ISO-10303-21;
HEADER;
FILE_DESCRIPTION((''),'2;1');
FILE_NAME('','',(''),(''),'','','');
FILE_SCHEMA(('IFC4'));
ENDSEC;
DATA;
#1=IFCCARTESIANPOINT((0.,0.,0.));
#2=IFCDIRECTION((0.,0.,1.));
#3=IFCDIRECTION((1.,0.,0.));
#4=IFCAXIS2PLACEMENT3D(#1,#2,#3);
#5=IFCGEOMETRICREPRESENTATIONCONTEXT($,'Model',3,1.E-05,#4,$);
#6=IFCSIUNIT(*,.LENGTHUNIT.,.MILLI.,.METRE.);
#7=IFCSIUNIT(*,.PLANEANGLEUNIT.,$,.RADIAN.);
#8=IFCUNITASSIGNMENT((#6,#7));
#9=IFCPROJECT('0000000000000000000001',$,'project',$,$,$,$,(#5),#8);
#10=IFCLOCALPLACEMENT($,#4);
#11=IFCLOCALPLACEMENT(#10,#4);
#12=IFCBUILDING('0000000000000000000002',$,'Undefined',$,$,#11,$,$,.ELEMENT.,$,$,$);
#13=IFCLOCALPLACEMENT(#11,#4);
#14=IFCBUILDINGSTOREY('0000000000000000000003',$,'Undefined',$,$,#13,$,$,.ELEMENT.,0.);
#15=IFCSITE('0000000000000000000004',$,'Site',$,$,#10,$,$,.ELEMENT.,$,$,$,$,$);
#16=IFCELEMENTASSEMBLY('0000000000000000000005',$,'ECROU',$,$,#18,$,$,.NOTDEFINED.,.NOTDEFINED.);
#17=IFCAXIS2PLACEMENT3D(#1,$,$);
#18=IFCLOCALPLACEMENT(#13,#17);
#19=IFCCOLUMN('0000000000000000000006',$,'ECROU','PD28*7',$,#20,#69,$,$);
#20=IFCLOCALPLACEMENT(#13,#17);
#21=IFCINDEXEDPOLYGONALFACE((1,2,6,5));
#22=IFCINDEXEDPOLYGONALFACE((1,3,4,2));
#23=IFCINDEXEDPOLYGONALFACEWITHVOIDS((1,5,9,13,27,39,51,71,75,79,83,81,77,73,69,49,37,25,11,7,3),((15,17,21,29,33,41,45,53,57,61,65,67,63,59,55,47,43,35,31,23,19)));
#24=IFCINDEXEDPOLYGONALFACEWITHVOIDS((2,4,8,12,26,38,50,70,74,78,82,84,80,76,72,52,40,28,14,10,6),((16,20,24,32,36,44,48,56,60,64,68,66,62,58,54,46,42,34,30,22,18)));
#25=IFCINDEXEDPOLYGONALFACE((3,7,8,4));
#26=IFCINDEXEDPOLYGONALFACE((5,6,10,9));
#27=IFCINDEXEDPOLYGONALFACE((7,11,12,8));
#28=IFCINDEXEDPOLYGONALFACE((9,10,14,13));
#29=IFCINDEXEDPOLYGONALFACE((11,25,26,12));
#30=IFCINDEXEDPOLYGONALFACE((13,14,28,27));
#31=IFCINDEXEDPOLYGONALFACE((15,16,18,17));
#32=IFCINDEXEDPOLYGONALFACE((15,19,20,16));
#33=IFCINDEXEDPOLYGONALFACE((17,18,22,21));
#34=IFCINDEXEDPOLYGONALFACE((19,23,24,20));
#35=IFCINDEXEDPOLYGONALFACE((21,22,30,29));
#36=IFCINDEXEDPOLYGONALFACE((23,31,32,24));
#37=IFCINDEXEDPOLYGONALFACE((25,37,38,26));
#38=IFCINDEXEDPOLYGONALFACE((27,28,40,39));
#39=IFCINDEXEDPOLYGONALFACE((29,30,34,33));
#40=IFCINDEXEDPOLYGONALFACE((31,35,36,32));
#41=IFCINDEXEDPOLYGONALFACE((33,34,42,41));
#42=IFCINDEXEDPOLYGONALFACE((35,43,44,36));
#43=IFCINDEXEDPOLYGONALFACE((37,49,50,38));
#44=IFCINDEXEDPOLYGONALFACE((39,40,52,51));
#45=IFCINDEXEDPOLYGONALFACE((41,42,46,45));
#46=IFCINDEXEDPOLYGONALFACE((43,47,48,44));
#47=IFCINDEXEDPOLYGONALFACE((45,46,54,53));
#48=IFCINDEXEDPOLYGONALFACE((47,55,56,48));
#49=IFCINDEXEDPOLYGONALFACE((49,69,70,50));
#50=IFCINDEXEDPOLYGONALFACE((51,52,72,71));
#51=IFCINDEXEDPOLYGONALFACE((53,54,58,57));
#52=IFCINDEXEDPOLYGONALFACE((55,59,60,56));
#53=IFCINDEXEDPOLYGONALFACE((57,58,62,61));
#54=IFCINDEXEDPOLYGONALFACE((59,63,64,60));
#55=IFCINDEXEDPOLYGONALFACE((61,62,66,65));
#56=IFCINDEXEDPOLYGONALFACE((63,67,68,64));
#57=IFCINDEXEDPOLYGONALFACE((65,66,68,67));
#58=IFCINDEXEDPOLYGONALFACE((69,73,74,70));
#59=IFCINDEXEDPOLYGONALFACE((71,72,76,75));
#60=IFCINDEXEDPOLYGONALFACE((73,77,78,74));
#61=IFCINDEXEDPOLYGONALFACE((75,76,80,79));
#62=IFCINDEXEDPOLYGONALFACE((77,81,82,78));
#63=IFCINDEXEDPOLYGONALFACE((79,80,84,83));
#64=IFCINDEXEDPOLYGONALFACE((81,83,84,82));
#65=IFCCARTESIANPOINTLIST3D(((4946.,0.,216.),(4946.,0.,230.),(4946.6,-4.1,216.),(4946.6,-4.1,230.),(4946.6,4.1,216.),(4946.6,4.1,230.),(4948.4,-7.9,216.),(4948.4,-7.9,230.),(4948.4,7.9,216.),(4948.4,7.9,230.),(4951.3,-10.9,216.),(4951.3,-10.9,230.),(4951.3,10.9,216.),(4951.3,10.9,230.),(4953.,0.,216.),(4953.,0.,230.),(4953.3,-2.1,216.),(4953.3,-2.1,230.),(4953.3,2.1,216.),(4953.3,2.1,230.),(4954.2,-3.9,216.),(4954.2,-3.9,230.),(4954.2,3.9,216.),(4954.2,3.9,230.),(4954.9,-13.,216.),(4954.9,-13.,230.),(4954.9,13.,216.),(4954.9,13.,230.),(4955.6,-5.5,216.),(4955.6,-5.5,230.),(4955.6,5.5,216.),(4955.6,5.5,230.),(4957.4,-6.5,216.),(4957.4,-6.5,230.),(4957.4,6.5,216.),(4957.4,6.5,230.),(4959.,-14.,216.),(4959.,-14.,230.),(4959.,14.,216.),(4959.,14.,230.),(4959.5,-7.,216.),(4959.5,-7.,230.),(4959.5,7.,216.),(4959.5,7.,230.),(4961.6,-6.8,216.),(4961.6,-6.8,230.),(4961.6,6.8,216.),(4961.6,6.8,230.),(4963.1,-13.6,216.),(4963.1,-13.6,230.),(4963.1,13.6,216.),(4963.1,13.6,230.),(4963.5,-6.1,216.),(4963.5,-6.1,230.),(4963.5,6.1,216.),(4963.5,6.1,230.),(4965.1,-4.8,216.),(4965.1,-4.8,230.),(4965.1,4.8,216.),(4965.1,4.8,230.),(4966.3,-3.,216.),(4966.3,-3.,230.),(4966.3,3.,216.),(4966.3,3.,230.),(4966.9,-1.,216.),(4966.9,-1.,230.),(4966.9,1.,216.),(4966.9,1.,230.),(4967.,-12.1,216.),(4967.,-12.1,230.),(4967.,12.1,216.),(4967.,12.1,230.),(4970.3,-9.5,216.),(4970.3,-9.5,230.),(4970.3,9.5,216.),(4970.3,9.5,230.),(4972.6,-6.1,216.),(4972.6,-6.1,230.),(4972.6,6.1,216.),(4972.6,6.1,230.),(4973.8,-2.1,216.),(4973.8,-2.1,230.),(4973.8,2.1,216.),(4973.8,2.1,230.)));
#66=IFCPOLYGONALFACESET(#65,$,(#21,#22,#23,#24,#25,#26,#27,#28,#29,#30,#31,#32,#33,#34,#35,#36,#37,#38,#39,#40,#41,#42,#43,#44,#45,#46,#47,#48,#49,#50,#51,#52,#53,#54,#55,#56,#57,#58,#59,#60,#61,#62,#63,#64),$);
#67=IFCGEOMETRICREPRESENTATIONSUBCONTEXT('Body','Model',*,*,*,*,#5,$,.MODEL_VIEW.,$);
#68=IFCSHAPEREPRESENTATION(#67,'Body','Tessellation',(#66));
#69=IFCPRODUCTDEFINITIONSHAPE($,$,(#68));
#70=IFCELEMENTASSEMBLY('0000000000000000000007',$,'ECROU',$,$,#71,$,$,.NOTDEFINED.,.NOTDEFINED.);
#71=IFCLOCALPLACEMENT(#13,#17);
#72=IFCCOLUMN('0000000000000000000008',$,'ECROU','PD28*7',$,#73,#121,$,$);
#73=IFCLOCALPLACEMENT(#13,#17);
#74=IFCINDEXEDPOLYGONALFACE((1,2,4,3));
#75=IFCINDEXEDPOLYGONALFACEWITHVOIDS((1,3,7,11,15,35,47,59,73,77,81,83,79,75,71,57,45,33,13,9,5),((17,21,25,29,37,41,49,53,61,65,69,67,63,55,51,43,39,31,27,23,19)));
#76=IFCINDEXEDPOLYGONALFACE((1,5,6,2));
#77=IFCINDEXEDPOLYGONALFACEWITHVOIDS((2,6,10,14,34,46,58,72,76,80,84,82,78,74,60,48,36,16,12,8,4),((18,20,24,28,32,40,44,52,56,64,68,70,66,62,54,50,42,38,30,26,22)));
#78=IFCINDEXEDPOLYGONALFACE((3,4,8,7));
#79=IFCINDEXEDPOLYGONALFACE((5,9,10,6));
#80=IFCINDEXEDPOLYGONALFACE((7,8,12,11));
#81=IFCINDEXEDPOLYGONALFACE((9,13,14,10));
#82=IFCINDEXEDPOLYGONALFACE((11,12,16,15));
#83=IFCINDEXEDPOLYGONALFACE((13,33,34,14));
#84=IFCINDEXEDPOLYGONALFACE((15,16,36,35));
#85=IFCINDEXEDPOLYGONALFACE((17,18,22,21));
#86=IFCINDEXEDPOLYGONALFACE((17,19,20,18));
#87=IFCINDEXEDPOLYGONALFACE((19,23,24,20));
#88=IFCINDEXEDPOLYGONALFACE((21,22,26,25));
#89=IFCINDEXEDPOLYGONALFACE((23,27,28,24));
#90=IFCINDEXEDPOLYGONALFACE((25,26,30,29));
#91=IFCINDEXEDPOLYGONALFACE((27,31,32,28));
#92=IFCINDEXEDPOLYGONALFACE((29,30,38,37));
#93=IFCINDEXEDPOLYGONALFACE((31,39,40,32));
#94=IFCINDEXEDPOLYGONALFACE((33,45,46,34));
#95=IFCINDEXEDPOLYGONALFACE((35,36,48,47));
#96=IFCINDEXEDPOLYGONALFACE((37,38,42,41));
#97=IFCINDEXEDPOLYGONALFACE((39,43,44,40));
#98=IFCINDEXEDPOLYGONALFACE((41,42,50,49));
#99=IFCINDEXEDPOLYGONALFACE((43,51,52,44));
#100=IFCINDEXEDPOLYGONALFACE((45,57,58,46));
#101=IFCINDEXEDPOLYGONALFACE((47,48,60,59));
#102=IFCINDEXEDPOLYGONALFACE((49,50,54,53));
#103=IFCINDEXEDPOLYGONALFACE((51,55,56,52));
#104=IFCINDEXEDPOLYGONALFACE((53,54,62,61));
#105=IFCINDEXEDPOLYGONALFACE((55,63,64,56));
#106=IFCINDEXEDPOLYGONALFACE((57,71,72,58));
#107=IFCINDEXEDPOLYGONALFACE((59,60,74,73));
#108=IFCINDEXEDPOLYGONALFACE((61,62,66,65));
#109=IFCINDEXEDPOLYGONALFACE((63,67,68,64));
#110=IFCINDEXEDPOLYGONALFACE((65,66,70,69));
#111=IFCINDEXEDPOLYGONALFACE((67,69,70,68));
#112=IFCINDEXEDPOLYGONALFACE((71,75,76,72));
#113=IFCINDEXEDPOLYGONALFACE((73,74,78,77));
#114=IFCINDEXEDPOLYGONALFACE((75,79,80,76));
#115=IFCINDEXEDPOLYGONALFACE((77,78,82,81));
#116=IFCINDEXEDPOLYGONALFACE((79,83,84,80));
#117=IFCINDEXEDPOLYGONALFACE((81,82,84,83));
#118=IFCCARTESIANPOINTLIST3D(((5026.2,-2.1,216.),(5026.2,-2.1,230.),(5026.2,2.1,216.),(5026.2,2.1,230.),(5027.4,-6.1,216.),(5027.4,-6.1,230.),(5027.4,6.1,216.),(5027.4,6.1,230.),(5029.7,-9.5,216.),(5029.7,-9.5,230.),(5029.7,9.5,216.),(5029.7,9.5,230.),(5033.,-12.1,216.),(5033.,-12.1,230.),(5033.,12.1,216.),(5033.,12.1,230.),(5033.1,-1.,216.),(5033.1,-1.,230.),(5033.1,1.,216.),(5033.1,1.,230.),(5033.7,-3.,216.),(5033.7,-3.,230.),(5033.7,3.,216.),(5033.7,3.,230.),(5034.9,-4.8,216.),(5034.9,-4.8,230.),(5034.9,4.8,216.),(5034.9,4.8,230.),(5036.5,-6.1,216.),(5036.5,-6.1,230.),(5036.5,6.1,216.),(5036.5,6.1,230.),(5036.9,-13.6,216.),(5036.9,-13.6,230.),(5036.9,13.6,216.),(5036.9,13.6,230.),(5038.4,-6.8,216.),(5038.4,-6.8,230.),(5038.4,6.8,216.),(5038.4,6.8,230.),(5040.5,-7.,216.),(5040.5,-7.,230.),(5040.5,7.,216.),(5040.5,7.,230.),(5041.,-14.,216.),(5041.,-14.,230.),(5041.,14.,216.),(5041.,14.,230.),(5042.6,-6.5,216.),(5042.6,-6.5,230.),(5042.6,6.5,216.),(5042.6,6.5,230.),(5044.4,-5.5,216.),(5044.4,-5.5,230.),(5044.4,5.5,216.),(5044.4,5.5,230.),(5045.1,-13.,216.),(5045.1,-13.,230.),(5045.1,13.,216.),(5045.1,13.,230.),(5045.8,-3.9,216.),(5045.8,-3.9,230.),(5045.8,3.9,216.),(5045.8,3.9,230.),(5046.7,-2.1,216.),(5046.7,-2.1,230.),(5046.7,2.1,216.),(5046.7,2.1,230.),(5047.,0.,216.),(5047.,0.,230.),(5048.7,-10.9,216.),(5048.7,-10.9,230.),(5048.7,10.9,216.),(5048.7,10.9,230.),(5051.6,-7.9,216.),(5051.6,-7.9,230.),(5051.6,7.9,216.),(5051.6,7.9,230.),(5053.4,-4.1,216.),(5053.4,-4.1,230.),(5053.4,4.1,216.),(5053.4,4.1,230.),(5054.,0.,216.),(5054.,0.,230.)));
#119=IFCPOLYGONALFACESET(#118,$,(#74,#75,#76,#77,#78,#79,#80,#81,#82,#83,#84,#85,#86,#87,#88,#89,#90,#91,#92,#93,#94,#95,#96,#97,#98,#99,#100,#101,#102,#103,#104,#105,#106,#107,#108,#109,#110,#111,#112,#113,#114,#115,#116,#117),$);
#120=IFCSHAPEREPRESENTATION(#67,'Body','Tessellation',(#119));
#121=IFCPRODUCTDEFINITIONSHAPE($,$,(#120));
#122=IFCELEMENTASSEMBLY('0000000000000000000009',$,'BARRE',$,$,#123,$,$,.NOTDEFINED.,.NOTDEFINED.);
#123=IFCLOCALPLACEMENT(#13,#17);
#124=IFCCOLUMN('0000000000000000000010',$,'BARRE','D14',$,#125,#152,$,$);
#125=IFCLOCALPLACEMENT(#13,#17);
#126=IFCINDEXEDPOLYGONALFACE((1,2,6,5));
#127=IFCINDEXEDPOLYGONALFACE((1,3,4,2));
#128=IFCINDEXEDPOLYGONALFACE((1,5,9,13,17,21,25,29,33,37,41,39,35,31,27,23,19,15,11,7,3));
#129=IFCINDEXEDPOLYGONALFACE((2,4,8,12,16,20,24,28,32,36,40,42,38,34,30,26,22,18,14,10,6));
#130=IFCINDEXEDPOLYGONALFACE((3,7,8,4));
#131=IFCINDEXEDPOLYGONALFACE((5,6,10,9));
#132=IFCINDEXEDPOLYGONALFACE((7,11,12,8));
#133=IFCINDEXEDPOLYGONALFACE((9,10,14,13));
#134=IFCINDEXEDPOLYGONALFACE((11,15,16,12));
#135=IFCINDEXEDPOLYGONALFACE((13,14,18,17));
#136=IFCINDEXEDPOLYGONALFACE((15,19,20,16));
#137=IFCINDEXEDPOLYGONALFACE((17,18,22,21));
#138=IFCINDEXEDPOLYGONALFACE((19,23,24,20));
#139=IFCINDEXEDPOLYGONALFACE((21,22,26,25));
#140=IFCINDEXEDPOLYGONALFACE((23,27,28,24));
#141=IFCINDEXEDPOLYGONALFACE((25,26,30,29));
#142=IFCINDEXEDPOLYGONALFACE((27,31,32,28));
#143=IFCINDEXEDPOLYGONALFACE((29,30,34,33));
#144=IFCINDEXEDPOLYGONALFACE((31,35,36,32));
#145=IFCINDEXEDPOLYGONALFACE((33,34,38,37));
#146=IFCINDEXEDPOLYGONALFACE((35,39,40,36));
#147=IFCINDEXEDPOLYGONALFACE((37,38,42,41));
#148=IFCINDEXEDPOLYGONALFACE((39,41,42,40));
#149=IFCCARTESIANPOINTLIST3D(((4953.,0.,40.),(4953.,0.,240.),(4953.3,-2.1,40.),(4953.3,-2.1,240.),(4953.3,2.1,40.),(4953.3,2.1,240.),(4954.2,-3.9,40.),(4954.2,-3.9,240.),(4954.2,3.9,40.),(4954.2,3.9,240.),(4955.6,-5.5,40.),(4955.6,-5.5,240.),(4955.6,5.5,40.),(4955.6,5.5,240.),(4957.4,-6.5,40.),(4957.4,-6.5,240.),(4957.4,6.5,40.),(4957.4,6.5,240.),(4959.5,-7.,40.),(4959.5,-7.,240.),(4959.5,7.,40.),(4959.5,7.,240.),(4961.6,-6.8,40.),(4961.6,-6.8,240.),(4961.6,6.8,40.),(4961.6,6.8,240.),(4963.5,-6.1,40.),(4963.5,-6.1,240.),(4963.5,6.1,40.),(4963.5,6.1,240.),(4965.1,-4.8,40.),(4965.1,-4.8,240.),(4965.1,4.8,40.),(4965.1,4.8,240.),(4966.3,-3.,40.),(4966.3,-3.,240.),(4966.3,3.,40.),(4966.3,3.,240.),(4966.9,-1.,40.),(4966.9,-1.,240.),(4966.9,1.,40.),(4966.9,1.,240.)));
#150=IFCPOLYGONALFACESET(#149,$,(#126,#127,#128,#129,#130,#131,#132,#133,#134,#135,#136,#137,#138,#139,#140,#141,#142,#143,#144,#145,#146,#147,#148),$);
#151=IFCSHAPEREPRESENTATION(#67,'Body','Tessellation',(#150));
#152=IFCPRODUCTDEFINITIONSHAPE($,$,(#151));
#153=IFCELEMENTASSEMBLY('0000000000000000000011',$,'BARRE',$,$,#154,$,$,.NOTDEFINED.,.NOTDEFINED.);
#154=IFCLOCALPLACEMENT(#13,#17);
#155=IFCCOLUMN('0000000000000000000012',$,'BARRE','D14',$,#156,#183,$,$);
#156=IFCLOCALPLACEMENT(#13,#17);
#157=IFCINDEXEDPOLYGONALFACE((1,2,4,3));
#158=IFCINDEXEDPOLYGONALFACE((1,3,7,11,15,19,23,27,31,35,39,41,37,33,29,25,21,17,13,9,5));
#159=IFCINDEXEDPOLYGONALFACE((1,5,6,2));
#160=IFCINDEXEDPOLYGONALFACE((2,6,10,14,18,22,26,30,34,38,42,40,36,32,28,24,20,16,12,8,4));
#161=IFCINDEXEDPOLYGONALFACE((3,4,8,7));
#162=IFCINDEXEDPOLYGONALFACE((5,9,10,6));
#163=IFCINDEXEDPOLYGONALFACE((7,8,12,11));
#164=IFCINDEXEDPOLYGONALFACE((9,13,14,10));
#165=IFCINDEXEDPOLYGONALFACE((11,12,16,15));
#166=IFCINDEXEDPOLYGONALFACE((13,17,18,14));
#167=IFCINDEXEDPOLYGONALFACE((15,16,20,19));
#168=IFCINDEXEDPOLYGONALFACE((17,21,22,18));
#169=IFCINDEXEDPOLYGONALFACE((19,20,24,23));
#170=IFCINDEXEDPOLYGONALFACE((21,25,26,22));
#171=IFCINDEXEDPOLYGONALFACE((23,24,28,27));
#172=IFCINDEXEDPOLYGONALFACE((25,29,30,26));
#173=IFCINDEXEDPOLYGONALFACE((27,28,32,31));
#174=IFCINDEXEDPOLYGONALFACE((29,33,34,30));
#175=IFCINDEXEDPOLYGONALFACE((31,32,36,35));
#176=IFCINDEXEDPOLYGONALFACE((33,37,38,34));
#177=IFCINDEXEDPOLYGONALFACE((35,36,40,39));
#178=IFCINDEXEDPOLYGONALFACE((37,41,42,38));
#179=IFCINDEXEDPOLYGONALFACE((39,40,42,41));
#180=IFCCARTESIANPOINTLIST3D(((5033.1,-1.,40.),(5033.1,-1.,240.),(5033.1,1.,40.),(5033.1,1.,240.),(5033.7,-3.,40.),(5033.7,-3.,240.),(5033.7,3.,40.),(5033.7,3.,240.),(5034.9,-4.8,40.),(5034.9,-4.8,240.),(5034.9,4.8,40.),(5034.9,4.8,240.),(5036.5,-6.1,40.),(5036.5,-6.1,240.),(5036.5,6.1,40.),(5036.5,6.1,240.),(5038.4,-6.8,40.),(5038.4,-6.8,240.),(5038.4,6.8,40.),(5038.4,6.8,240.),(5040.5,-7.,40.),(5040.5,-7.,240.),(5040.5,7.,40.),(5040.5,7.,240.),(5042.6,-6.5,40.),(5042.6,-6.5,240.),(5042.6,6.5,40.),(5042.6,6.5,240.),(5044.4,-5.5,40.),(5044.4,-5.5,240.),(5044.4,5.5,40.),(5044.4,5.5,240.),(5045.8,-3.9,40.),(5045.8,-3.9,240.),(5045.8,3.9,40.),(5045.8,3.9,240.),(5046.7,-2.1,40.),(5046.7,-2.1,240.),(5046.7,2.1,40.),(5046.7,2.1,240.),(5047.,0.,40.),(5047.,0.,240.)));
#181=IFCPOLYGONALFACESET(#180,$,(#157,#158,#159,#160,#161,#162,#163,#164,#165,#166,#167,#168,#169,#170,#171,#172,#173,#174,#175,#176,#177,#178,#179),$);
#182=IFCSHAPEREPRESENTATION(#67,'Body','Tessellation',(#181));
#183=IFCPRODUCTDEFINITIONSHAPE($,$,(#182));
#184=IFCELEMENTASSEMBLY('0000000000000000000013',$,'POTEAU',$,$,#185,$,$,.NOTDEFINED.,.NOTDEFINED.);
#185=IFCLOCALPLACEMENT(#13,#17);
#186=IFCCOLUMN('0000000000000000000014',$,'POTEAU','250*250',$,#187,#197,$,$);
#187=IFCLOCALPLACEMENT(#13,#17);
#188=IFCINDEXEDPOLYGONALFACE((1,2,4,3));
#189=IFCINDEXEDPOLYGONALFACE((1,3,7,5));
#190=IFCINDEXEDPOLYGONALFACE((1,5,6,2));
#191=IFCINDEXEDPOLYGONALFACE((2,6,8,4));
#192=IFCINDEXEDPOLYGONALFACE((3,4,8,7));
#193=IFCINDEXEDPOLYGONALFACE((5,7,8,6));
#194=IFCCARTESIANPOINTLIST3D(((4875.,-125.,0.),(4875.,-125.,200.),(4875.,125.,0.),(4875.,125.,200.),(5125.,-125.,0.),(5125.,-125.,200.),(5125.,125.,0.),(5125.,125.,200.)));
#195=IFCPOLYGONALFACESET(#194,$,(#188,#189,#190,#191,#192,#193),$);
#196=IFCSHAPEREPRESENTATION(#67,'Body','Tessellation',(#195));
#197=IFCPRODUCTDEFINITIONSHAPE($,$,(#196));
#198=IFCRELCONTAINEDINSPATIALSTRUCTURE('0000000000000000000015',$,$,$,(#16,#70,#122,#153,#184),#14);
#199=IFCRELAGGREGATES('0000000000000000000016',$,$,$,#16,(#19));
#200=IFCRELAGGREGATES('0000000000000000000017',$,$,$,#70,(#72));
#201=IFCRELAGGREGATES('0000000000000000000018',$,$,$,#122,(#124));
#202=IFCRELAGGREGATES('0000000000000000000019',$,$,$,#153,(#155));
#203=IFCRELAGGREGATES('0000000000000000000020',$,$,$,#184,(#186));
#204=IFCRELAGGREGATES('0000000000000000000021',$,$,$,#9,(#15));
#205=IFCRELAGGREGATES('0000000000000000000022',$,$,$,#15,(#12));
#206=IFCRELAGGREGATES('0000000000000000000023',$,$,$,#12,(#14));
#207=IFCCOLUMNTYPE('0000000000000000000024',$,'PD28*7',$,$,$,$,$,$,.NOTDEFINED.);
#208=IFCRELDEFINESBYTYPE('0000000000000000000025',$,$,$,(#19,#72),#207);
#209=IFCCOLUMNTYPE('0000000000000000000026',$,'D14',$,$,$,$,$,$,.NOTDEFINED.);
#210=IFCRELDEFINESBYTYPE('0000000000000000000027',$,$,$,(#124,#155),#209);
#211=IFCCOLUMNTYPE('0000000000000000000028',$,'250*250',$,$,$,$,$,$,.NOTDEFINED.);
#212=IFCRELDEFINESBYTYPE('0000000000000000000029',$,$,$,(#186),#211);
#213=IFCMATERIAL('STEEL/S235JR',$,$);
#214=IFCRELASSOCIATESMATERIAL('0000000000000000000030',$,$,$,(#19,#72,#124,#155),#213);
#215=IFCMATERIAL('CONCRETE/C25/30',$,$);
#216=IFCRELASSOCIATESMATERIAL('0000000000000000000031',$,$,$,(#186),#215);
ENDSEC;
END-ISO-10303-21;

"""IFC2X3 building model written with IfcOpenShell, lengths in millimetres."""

from ifc_helpers import new_model, si_unit, frame, origin_with_axes, origin_2d_with_axis, place, context, subcontext, project, spatial, rectangle, circle, hollow_circle, extrude, material, type_object, element, aggregate, save


model = new_model("IFC2X3")

# Units and contexts
model_context = context("Model", 3, precision=1e-05, world=origin_with_axes())
body_context = subcontext(model_context, "Body", "Model", "MODEL_VIEW")
ifc_project = project(units=[si_unit("LENGTHUNIT", "METRE", prefix="MILLI"), si_unit("PLANEANGLEUNIT", "RADIAN")], contexts=[model_context])

# Site, building, storey
site_placement = place(None, origin_with_axes())
site = spatial("IfcSite", under=ifc_project, at=site_placement, Name="Site", CompositionType="ELEMENT")
building_placement = place(site_placement, origin_with_axes())
building = spatial("IfcBuilding", under=site, at=building_placement, Name="Undefined", CompositionType="ELEMENT")
storey_placement = place(building_placement, origin_with_axes())
storey = spatial("IfcBuildingStorey", under=building, at=storey_placement, Name="Undefined", CompositionType="ELEMENT", Elevation=0.0)

# Element assemblies, columns
assembly_1_placement = place(storey_placement, origin_with_axes())
assembly_1 = element("IfcElementAssembly", 1, at=assembly_1_placement, inside=storey, Name="ECROU", AssemblyPlace="NOTDEFINED", PredefinedType="NOTDEFINED")
ifc_material_1 = material(Name="STEEL/S235JR")
column_type_1 = type_object("IfcColumnType", Name="PD28*7", PredefinedType="NOTDEFINED")
column_1_placement = place(assembly_1_placement, frame((4960.0, 0.0, 230.0), z_axis=(0.0, 0.0, -1.0), x_axis=(0.0, -1.0, 0.0)))
column_1 = element("IfcColumn", 2, at=column_1_placement, type_object=column_type_1, material=ifc_material_1, Name="ECROU", Description="PD28*7", context=body_context, shape_type="SweptSolid", body=[
    extrude(hollow_circle(Radius=14.0, WallThickness=7.0, at=origin_2d_with_axis()), frame((0.0, 0.0, 14.0), z_axis=(0.0, 0.0, -1.0), x_axis=(0.0, 1.0, 0.0)), (0.0, 0.0, 1.0), 14.0),
])
aggregate(assembly_1, [column_1])
assembly_2_placement = place(storey_placement, origin_with_axes())
assembly_2 = element("IfcElementAssembly", 3, at=assembly_2_placement, inside=storey, Name="ECROU", AssemblyPlace="NOTDEFINED", PredefinedType="NOTDEFINED")
column_2_placement = place(assembly_2_placement, frame((5040.0, 0.0, 230.0), z_axis=(0.0, 0.0, -1.0), x_axis=(0.0, 1.0, 0.0)))
column_2 = element("IfcColumn", 4, at=column_2_placement, type_object=column_type_1, material=ifc_material_1, Name="ECROU", Description="PD28*7", context=body_context, shape_type="SweptSolid", body=[
    extrude(hollow_circle(Radius=14.0, WallThickness=7.0, at=origin_2d_with_axis()), frame((0.0, 0.0, 14.0), z_axis=(0.0, 0.0, -1.0), x_axis=(0.0, 1.0, 0.0)), (0.0, 0.0, 1.0), 14.0),
])
aggregate(assembly_2, [column_2])
assembly_3_placement = place(storey_placement, origin_with_axes())
assembly_3 = element("IfcElementAssembly", 5, at=assembly_3_placement, inside=storey, Name="BARRE", AssemblyPlace="NOTDEFINED", PredefinedType="NOTDEFINED")
column_type_2 = type_object("IfcColumnType", Name="D14", PredefinedType="NOTDEFINED")
column_3_placement = place(assembly_3_placement, frame((4960.0, 0.0, 240.0), z_axis=(0.0, 0.0, -1.0), x_axis=(0.0, -1.0, 0.0)))
column_3 = element("IfcColumn", 6, at=column_3_placement, type_object=column_type_2, material=ifc_material_1, Name="BARRE", Description="D14", context=body_context, shape_type="SweptSolid", body=[
    extrude(circle(Radius=7.0, at=origin_2d_with_axis()), frame((0.0, 0.0, 200.0), z_axis=(0.0, 0.0, -1.0), x_axis=(0.0, 1.0, 0.0)), (0.0, 0.0, 1.0), 200.0),
])
aggregate(assembly_3, [column_3])
assembly_4_placement = place(storey_placement, origin_with_axes())
assembly_4 = element("IfcElementAssembly", 7, at=assembly_4_placement, inside=storey, Name="BARRE", AssemblyPlace="NOTDEFINED", PredefinedType="NOTDEFINED")
column_4_placement = place(assembly_4_placement, frame((5040.0, 0.0, 240.0), z_axis=(0.0, 0.0, -1.0), x_axis=(0.0, 1.0, 0.0)))
column_4 = element("IfcColumn", 8, at=column_4_placement, type_object=column_type_2, material=ifc_material_1, Name="BARRE", Description="D14", context=body_context, shape_type="SweptSolid", body=[
    extrude(circle(Radius=7.0, at=origin_2d_with_axis()), frame((0.0, 0.0, 200.0), z_axis=(0.0, 0.0, -1.0), x_axis=(0.0, 1.0, 0.0)), (0.0, 0.0, 1.0), 200.0),
])
aggregate(assembly_4, [column_4])
assembly_5_placement = place(storey_placement, origin_with_axes())
assembly_5 = element("IfcElementAssembly", 9, at=assembly_5_placement, inside=storey, Name="POTEAU", AssemblyPlace="NOTDEFINED", PredefinedType="NOTDEFINED")
ifc_material_2 = material(Name="CONCRETE/C25/30")
column_type_3 = type_object("IfcColumnType", Name="250*250", PredefinedType="NOTDEFINED")
column_5_placement = place(assembly_5_placement, frame((5000.0, 0.0, 0.0), z_axis=(0.0, 0.0, 1.0), x_axis=(0.0, 1.0, 0.0)))
column_5 = element("IfcColumn", 10, at=column_5_placement, type_object=column_type_3, material=ifc_material_2, Name="POTEAU", Description="250*250", context=body_context, shape_type="SweptSolid", body=[
    extrude(rectangle(XDim=250.0, YDim=250.0, at=origin_2d_with_axis()), frame((0.0, 0.0, 200.0), z_axis=(0.0, 0.0, -1.0), x_axis=(0.0, 1.0, 0.0)), (0.0, 0.0, 1.0), 200.0),
])
aggregate(assembly_5, [column_5])

save(model, "model.ifc")
